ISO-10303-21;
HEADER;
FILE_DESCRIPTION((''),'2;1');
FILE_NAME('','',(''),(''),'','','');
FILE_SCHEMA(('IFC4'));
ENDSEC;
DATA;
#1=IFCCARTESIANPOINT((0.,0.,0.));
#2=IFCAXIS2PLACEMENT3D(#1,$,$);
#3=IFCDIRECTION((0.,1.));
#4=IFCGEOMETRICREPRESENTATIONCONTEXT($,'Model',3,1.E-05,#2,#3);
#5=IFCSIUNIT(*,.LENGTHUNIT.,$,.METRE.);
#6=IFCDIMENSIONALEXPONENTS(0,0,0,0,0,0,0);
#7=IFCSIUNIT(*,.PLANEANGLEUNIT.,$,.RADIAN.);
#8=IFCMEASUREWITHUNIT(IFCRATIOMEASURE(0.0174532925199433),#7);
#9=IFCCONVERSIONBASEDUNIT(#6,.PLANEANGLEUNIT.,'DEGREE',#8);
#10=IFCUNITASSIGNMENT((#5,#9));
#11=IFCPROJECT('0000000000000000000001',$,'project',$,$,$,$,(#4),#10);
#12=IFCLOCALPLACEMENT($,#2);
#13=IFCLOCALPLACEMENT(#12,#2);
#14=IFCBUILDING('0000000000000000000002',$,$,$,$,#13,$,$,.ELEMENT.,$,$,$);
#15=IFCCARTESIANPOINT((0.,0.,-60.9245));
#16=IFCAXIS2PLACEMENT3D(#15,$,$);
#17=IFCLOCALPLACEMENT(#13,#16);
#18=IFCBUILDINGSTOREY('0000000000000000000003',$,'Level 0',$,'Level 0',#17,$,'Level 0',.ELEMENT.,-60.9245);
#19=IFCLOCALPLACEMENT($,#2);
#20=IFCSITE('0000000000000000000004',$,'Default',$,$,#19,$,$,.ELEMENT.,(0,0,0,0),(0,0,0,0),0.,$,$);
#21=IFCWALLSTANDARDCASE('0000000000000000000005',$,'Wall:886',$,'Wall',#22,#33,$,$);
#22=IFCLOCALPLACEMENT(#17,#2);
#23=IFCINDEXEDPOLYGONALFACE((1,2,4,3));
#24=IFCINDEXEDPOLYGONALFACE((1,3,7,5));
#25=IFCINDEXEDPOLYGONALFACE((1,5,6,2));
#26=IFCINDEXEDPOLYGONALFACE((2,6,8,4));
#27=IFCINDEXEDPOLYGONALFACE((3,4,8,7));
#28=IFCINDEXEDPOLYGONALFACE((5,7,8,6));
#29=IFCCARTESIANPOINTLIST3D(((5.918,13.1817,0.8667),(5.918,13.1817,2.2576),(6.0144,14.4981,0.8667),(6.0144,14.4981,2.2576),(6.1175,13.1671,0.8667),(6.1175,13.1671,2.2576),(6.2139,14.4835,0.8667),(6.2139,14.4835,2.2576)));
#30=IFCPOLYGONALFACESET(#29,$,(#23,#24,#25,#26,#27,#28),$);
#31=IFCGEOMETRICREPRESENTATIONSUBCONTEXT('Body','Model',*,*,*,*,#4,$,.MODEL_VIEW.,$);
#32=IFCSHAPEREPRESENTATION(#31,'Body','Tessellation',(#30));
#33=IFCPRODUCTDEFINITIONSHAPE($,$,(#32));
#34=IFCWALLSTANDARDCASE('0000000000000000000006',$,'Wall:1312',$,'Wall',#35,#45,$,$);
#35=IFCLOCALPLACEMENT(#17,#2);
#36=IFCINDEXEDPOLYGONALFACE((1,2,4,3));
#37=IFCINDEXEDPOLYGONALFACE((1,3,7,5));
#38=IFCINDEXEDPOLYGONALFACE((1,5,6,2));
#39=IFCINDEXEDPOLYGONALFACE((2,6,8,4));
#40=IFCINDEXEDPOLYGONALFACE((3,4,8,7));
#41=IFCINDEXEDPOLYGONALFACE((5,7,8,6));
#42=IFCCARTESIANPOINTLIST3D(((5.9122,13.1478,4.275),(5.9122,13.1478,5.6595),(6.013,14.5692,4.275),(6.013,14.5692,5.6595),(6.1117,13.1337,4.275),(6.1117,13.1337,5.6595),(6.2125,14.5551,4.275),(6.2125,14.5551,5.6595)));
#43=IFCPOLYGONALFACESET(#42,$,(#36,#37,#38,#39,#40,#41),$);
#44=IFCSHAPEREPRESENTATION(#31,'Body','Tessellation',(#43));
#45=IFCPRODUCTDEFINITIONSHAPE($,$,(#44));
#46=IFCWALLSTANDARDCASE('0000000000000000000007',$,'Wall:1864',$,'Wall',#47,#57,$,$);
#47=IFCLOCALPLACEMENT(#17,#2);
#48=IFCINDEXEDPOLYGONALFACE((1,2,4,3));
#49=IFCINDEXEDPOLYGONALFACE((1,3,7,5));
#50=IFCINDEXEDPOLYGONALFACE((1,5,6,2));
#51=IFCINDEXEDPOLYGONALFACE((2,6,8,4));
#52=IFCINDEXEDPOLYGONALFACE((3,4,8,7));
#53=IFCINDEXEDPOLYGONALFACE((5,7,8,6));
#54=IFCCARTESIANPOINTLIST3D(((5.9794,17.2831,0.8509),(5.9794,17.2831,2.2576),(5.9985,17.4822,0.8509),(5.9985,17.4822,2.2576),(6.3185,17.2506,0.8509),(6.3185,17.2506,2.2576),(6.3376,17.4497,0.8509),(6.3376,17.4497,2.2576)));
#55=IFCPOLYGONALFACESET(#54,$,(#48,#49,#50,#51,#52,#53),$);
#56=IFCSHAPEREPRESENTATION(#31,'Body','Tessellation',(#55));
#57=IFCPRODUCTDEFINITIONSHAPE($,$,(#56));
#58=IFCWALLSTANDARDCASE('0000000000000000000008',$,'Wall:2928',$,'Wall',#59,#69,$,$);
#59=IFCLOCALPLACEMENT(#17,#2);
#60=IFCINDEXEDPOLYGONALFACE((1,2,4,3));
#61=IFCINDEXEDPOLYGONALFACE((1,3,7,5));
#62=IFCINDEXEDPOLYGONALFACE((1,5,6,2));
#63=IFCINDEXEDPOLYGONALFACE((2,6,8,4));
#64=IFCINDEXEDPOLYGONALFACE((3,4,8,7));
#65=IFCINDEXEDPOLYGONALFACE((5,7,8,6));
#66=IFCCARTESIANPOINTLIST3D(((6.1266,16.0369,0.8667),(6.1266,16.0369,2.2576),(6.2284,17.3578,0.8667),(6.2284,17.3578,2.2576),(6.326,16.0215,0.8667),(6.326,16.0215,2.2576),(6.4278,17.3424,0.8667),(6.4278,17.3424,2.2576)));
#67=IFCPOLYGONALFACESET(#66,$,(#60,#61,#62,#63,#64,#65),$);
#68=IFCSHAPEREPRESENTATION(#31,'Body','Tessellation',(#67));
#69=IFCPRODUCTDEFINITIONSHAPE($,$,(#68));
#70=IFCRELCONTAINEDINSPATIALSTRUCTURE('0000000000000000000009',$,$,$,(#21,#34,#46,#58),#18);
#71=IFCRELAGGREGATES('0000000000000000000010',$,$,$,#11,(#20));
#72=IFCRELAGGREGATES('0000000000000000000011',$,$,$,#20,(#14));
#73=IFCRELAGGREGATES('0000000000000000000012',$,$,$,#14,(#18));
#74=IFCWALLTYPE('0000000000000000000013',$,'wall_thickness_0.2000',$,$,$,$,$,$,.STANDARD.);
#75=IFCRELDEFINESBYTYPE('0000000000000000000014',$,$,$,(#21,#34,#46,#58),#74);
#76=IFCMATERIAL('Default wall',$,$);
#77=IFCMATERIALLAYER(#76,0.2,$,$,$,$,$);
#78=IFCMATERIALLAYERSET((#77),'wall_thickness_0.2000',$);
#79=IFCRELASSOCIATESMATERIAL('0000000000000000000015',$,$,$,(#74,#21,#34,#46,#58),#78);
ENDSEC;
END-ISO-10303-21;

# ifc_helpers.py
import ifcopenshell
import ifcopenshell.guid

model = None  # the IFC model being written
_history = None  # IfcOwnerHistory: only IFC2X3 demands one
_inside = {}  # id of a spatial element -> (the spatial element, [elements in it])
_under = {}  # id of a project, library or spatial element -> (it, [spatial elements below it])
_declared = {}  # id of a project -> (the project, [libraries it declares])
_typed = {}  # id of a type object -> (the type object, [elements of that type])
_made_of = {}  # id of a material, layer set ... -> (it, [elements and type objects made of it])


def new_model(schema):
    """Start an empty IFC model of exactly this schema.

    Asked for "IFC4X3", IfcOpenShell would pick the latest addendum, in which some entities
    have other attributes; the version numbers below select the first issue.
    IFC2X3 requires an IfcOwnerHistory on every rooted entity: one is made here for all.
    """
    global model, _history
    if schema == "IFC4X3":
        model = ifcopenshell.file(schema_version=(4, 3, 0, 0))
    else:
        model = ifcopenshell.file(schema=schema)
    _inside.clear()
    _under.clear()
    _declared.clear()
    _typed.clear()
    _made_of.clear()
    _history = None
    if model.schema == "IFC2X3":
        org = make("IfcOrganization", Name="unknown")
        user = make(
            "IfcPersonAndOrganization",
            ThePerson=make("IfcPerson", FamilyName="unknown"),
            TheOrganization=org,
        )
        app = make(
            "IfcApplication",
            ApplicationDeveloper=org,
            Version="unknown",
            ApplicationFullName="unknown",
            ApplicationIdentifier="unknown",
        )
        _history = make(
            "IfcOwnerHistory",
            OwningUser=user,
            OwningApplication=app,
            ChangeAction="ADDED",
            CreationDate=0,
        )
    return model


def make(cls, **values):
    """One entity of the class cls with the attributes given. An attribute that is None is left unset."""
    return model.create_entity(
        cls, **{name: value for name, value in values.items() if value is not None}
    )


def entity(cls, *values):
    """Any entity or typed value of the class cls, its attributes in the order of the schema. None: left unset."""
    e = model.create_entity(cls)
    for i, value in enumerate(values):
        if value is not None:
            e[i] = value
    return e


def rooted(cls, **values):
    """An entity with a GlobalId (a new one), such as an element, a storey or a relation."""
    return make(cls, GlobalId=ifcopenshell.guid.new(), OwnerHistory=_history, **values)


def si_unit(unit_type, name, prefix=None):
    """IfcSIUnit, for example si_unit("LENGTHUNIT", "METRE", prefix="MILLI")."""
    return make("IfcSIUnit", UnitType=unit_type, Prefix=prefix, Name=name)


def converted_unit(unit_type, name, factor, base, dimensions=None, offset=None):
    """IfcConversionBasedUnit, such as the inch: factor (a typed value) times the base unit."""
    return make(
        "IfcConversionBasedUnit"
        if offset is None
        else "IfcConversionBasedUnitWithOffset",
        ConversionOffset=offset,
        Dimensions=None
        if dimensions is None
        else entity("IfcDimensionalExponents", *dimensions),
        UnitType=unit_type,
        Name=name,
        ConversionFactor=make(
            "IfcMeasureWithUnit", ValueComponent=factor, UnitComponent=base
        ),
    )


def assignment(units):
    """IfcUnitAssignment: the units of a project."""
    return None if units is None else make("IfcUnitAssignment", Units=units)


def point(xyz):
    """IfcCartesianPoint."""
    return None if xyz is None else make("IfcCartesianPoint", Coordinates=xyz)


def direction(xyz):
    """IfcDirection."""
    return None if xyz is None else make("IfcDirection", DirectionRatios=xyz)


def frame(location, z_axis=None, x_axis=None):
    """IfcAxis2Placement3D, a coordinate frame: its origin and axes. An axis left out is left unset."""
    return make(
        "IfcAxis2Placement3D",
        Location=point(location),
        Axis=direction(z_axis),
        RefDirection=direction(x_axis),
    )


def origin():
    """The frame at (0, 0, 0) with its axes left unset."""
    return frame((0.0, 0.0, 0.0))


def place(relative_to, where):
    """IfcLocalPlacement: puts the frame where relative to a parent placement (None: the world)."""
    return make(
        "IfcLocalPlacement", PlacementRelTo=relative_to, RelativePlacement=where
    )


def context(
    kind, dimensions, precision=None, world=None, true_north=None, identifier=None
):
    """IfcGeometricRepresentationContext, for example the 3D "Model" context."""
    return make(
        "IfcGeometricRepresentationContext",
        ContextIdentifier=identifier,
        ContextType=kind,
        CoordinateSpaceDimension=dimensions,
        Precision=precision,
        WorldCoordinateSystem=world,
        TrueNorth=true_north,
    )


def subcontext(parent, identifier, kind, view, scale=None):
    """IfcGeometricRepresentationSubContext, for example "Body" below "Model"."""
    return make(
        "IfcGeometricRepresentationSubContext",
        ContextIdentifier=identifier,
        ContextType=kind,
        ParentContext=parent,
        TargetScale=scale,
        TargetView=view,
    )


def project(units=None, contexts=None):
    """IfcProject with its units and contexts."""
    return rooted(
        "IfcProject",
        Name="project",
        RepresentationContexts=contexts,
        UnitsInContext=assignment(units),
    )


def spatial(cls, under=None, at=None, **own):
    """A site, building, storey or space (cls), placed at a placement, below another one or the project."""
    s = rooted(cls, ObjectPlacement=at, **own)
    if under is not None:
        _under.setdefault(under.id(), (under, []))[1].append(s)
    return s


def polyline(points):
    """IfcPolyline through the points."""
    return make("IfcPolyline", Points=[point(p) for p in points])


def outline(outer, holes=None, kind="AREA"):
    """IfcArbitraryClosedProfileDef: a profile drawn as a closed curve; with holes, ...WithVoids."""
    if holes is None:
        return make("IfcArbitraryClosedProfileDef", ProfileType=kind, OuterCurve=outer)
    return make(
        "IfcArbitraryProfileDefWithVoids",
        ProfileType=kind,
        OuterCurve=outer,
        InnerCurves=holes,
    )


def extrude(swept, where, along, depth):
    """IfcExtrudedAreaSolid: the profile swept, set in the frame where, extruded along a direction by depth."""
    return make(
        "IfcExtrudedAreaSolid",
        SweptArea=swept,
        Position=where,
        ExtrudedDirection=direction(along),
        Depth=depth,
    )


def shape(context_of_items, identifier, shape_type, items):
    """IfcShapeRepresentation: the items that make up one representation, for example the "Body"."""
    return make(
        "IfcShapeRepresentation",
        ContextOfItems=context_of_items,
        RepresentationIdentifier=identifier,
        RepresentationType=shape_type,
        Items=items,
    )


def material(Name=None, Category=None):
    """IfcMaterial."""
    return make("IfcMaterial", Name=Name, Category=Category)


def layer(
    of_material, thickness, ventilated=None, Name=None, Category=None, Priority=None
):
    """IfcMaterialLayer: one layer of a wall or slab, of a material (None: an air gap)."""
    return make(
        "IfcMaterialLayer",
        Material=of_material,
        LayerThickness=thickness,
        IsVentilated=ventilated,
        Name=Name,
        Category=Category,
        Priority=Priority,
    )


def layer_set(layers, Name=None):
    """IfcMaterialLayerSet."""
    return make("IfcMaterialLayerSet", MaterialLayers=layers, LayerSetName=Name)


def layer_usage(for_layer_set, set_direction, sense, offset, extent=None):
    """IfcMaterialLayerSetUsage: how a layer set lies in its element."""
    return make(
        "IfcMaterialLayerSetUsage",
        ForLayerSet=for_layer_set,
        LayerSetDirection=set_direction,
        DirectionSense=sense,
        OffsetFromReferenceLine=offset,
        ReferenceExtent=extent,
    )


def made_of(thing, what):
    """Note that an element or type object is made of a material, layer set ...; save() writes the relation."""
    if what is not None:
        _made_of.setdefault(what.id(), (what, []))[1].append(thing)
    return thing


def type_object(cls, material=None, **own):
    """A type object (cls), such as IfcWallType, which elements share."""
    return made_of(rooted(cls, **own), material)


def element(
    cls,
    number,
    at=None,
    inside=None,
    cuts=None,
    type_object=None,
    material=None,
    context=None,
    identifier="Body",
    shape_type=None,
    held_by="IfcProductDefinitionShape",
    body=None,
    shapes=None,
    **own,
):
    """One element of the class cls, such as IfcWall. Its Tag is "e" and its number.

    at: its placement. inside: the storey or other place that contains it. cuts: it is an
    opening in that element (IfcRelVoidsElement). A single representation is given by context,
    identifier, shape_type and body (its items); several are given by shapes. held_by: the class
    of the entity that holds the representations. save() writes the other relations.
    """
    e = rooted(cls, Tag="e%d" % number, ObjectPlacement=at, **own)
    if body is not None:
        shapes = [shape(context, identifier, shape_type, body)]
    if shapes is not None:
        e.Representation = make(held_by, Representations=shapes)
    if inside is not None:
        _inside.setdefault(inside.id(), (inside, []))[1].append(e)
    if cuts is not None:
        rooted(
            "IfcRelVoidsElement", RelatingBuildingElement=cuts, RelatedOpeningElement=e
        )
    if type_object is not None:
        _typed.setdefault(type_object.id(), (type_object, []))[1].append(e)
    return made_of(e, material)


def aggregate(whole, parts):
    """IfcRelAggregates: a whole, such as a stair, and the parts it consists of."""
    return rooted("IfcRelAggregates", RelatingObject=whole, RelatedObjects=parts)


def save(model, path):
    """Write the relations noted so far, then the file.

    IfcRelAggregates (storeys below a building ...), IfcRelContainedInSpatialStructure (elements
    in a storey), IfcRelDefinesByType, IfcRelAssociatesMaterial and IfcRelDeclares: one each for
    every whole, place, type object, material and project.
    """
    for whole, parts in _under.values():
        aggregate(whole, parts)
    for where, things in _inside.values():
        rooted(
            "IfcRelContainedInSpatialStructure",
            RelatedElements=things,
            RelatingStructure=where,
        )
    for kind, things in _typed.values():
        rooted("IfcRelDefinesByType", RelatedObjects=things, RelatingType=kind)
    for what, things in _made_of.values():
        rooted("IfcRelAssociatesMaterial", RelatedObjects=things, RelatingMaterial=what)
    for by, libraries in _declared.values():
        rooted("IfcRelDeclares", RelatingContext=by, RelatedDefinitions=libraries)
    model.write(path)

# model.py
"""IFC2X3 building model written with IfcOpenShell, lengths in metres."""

from ifc_helpers import new_model, entity, si_unit, converted_unit, direction, frame, origin, place, context, subcontext, project, spatial, polyline, outline, extrude, material, layer, layer_set, layer_usage, type_object, element, save


model = new_model("IFC2X3")

# Units and contexts
model_context = context("Model", 3, precision=1e-05, world=origin(), true_north=direction((0.0, 1.0)))
body_context = subcontext(model_context, "Body", "Model", "MODEL_VIEW")
ifc_project = project(units=[si_unit("LENGTHUNIT", "METRE"), converted_unit("PLANEANGLEUNIT", "DEGREE", entity("IfcRatioMeasure", 0.0174532925199433), si_unit("PLANEANGLEUNIT", "RADIAN"), dimensions=[0, 0, 0, 0, 0, 0, 0])], contexts=[model_context])

# Site, building, storey
site_placement = place(None, origin())
site = spatial("IfcSite", under=ifc_project, at=site_placement, Name="Default", CompositionType="ELEMENT", RefLatitude=(0, 0, 0, 0), RefLongitude=(0, 0, 0, 0), RefElevation=0.0)
placement_1 = place(None, origin())
building_placement = place(placement_1, origin())
building = spatial("IfcBuilding", under=site, at=building_placement, CompositionType="ELEMENT")
storey_placement = place(building_placement, frame((0.0, 0.0, -60.9245)))
storey = spatial("IfcBuildingStorey", under=building, at=storey_placement, Name="Level 0", ObjectType="Level 0", LongName="Level 0", CompositionType="ELEMENT", Elevation=-60.9245)

# Walls
ifc_material_1 = material(Name="Default wall")
ifc_layer = layer(ifc_material_1, 0.2)
ifc_layer_set = layer_set([ifc_layer], Name="wall_thickness_0.2000")
ifc_layer_usage = layer_usage(ifc_layer_set, "AXIS2", "POSITIVE", -0.1)
wall_type = type_object("IfcWallType", Name="wall_thickness_0.2000", PredefinedType="STANDARD", material=ifc_layer_set)
placement_2 = place(building_placement, frame((0.0, 0.0, -60.0578)))
wall_1_placement = place(placement_2, frame((6.1142, 14.4908, 0.0), z_axis=(0.0, 0.0, 1.0), x_axis=(-0.073052, -0.997328, 0.0)))
element("IfcWallStandardCase", 1, at=wall_1_placement, inside=storey, type_object=wall_type, material=ifc_layer_usage, Name="Wall:886", ObjectType="Wall", context=body_context, shape_type="SweptSolid", body=[
    extrude(outline(polyline([(1.32, -0.1), (1.32, 0.1), (0.0, 0.1), (0.0, -0.1), (1.32, -0.1)])), origin(), (0.0, 0.0, 1.0), 1.3909),
])
placement_3 = place(building_placement, frame((0.0, 0.0, -56.6495)))
wall_2_placement = place(placement_3, frame((6.1127, 14.5622, 0.0), z_axis=(0.0, 0.0, 1.0), x_axis=(-0.070729, -0.997496, 0.0)))
element("IfcWallStandardCase", 2, at=wall_2_placement, inside=storey, type_object=wall_type, material=ifc_layer_usage, Name="Wall:1312", ObjectType="Wall", context=body_context, shape_type="SweptSolid", body=[
    extrude(outline(polyline([(1.425, -0.1), (1.425, 0.1), (0.0, 0.1), (0.0, -0.1), (1.425, -0.1)])), origin(), (0.0, 0.0, 1.0), 1.3845),
])

# Walls
placement_4 = place(building_placement, frame((0.0, 0.0, -60.0736)))
wall_3_placement = place(placement_4, frame((6.3281, 17.3501, 0.0), z_axis=(0.0, 0.0, 1.0), x_axis=(-0.995434, 0.095451, 0.0)))
element("IfcWallStandardCase", 3, at=wall_3_placement, inside=storey, type_object=wall_type, material=ifc_layer_usage, Name="Wall:1864", ObjectType="Wall", context=body_context, shape_type="SweptSolid", body=[
    extrude(outline(polyline([(0.3407, -0.1), (0.3407, 0.1), (0.0, 0.1), (0.0, -0.1), (0.3407, -0.1)])), origin(), (0.0, 0.0, 1.0), 1.4068),
])
placement_5 = place(building_placement, frame((0.0, 0.0, -60.0578)))
wall_4_placement = place(placement_5, frame((6.3281, 17.3501, 0.0), z_axis=(0.0, 0.0, 1.0), x_axis=(-0.076863, -0.997042, 0.0)))
element("IfcWallStandardCase", 4, at=wall_4_placement, inside=storey, type_object=wall_type, material=ifc_layer_usage, Name="Wall:2928", ObjectType="Wall", context=body_context, shape_type="SweptSolid", body=[
    extrude(outline(polyline([(1.3248, -0.1), (1.3248, 0.1), (0.0, 0.1), (0.0, -0.1), (1.3248, -0.1)])), origin(), (0.0, 0.0, 1.0), 1.3909),
])

save(model, "model.ifc")
